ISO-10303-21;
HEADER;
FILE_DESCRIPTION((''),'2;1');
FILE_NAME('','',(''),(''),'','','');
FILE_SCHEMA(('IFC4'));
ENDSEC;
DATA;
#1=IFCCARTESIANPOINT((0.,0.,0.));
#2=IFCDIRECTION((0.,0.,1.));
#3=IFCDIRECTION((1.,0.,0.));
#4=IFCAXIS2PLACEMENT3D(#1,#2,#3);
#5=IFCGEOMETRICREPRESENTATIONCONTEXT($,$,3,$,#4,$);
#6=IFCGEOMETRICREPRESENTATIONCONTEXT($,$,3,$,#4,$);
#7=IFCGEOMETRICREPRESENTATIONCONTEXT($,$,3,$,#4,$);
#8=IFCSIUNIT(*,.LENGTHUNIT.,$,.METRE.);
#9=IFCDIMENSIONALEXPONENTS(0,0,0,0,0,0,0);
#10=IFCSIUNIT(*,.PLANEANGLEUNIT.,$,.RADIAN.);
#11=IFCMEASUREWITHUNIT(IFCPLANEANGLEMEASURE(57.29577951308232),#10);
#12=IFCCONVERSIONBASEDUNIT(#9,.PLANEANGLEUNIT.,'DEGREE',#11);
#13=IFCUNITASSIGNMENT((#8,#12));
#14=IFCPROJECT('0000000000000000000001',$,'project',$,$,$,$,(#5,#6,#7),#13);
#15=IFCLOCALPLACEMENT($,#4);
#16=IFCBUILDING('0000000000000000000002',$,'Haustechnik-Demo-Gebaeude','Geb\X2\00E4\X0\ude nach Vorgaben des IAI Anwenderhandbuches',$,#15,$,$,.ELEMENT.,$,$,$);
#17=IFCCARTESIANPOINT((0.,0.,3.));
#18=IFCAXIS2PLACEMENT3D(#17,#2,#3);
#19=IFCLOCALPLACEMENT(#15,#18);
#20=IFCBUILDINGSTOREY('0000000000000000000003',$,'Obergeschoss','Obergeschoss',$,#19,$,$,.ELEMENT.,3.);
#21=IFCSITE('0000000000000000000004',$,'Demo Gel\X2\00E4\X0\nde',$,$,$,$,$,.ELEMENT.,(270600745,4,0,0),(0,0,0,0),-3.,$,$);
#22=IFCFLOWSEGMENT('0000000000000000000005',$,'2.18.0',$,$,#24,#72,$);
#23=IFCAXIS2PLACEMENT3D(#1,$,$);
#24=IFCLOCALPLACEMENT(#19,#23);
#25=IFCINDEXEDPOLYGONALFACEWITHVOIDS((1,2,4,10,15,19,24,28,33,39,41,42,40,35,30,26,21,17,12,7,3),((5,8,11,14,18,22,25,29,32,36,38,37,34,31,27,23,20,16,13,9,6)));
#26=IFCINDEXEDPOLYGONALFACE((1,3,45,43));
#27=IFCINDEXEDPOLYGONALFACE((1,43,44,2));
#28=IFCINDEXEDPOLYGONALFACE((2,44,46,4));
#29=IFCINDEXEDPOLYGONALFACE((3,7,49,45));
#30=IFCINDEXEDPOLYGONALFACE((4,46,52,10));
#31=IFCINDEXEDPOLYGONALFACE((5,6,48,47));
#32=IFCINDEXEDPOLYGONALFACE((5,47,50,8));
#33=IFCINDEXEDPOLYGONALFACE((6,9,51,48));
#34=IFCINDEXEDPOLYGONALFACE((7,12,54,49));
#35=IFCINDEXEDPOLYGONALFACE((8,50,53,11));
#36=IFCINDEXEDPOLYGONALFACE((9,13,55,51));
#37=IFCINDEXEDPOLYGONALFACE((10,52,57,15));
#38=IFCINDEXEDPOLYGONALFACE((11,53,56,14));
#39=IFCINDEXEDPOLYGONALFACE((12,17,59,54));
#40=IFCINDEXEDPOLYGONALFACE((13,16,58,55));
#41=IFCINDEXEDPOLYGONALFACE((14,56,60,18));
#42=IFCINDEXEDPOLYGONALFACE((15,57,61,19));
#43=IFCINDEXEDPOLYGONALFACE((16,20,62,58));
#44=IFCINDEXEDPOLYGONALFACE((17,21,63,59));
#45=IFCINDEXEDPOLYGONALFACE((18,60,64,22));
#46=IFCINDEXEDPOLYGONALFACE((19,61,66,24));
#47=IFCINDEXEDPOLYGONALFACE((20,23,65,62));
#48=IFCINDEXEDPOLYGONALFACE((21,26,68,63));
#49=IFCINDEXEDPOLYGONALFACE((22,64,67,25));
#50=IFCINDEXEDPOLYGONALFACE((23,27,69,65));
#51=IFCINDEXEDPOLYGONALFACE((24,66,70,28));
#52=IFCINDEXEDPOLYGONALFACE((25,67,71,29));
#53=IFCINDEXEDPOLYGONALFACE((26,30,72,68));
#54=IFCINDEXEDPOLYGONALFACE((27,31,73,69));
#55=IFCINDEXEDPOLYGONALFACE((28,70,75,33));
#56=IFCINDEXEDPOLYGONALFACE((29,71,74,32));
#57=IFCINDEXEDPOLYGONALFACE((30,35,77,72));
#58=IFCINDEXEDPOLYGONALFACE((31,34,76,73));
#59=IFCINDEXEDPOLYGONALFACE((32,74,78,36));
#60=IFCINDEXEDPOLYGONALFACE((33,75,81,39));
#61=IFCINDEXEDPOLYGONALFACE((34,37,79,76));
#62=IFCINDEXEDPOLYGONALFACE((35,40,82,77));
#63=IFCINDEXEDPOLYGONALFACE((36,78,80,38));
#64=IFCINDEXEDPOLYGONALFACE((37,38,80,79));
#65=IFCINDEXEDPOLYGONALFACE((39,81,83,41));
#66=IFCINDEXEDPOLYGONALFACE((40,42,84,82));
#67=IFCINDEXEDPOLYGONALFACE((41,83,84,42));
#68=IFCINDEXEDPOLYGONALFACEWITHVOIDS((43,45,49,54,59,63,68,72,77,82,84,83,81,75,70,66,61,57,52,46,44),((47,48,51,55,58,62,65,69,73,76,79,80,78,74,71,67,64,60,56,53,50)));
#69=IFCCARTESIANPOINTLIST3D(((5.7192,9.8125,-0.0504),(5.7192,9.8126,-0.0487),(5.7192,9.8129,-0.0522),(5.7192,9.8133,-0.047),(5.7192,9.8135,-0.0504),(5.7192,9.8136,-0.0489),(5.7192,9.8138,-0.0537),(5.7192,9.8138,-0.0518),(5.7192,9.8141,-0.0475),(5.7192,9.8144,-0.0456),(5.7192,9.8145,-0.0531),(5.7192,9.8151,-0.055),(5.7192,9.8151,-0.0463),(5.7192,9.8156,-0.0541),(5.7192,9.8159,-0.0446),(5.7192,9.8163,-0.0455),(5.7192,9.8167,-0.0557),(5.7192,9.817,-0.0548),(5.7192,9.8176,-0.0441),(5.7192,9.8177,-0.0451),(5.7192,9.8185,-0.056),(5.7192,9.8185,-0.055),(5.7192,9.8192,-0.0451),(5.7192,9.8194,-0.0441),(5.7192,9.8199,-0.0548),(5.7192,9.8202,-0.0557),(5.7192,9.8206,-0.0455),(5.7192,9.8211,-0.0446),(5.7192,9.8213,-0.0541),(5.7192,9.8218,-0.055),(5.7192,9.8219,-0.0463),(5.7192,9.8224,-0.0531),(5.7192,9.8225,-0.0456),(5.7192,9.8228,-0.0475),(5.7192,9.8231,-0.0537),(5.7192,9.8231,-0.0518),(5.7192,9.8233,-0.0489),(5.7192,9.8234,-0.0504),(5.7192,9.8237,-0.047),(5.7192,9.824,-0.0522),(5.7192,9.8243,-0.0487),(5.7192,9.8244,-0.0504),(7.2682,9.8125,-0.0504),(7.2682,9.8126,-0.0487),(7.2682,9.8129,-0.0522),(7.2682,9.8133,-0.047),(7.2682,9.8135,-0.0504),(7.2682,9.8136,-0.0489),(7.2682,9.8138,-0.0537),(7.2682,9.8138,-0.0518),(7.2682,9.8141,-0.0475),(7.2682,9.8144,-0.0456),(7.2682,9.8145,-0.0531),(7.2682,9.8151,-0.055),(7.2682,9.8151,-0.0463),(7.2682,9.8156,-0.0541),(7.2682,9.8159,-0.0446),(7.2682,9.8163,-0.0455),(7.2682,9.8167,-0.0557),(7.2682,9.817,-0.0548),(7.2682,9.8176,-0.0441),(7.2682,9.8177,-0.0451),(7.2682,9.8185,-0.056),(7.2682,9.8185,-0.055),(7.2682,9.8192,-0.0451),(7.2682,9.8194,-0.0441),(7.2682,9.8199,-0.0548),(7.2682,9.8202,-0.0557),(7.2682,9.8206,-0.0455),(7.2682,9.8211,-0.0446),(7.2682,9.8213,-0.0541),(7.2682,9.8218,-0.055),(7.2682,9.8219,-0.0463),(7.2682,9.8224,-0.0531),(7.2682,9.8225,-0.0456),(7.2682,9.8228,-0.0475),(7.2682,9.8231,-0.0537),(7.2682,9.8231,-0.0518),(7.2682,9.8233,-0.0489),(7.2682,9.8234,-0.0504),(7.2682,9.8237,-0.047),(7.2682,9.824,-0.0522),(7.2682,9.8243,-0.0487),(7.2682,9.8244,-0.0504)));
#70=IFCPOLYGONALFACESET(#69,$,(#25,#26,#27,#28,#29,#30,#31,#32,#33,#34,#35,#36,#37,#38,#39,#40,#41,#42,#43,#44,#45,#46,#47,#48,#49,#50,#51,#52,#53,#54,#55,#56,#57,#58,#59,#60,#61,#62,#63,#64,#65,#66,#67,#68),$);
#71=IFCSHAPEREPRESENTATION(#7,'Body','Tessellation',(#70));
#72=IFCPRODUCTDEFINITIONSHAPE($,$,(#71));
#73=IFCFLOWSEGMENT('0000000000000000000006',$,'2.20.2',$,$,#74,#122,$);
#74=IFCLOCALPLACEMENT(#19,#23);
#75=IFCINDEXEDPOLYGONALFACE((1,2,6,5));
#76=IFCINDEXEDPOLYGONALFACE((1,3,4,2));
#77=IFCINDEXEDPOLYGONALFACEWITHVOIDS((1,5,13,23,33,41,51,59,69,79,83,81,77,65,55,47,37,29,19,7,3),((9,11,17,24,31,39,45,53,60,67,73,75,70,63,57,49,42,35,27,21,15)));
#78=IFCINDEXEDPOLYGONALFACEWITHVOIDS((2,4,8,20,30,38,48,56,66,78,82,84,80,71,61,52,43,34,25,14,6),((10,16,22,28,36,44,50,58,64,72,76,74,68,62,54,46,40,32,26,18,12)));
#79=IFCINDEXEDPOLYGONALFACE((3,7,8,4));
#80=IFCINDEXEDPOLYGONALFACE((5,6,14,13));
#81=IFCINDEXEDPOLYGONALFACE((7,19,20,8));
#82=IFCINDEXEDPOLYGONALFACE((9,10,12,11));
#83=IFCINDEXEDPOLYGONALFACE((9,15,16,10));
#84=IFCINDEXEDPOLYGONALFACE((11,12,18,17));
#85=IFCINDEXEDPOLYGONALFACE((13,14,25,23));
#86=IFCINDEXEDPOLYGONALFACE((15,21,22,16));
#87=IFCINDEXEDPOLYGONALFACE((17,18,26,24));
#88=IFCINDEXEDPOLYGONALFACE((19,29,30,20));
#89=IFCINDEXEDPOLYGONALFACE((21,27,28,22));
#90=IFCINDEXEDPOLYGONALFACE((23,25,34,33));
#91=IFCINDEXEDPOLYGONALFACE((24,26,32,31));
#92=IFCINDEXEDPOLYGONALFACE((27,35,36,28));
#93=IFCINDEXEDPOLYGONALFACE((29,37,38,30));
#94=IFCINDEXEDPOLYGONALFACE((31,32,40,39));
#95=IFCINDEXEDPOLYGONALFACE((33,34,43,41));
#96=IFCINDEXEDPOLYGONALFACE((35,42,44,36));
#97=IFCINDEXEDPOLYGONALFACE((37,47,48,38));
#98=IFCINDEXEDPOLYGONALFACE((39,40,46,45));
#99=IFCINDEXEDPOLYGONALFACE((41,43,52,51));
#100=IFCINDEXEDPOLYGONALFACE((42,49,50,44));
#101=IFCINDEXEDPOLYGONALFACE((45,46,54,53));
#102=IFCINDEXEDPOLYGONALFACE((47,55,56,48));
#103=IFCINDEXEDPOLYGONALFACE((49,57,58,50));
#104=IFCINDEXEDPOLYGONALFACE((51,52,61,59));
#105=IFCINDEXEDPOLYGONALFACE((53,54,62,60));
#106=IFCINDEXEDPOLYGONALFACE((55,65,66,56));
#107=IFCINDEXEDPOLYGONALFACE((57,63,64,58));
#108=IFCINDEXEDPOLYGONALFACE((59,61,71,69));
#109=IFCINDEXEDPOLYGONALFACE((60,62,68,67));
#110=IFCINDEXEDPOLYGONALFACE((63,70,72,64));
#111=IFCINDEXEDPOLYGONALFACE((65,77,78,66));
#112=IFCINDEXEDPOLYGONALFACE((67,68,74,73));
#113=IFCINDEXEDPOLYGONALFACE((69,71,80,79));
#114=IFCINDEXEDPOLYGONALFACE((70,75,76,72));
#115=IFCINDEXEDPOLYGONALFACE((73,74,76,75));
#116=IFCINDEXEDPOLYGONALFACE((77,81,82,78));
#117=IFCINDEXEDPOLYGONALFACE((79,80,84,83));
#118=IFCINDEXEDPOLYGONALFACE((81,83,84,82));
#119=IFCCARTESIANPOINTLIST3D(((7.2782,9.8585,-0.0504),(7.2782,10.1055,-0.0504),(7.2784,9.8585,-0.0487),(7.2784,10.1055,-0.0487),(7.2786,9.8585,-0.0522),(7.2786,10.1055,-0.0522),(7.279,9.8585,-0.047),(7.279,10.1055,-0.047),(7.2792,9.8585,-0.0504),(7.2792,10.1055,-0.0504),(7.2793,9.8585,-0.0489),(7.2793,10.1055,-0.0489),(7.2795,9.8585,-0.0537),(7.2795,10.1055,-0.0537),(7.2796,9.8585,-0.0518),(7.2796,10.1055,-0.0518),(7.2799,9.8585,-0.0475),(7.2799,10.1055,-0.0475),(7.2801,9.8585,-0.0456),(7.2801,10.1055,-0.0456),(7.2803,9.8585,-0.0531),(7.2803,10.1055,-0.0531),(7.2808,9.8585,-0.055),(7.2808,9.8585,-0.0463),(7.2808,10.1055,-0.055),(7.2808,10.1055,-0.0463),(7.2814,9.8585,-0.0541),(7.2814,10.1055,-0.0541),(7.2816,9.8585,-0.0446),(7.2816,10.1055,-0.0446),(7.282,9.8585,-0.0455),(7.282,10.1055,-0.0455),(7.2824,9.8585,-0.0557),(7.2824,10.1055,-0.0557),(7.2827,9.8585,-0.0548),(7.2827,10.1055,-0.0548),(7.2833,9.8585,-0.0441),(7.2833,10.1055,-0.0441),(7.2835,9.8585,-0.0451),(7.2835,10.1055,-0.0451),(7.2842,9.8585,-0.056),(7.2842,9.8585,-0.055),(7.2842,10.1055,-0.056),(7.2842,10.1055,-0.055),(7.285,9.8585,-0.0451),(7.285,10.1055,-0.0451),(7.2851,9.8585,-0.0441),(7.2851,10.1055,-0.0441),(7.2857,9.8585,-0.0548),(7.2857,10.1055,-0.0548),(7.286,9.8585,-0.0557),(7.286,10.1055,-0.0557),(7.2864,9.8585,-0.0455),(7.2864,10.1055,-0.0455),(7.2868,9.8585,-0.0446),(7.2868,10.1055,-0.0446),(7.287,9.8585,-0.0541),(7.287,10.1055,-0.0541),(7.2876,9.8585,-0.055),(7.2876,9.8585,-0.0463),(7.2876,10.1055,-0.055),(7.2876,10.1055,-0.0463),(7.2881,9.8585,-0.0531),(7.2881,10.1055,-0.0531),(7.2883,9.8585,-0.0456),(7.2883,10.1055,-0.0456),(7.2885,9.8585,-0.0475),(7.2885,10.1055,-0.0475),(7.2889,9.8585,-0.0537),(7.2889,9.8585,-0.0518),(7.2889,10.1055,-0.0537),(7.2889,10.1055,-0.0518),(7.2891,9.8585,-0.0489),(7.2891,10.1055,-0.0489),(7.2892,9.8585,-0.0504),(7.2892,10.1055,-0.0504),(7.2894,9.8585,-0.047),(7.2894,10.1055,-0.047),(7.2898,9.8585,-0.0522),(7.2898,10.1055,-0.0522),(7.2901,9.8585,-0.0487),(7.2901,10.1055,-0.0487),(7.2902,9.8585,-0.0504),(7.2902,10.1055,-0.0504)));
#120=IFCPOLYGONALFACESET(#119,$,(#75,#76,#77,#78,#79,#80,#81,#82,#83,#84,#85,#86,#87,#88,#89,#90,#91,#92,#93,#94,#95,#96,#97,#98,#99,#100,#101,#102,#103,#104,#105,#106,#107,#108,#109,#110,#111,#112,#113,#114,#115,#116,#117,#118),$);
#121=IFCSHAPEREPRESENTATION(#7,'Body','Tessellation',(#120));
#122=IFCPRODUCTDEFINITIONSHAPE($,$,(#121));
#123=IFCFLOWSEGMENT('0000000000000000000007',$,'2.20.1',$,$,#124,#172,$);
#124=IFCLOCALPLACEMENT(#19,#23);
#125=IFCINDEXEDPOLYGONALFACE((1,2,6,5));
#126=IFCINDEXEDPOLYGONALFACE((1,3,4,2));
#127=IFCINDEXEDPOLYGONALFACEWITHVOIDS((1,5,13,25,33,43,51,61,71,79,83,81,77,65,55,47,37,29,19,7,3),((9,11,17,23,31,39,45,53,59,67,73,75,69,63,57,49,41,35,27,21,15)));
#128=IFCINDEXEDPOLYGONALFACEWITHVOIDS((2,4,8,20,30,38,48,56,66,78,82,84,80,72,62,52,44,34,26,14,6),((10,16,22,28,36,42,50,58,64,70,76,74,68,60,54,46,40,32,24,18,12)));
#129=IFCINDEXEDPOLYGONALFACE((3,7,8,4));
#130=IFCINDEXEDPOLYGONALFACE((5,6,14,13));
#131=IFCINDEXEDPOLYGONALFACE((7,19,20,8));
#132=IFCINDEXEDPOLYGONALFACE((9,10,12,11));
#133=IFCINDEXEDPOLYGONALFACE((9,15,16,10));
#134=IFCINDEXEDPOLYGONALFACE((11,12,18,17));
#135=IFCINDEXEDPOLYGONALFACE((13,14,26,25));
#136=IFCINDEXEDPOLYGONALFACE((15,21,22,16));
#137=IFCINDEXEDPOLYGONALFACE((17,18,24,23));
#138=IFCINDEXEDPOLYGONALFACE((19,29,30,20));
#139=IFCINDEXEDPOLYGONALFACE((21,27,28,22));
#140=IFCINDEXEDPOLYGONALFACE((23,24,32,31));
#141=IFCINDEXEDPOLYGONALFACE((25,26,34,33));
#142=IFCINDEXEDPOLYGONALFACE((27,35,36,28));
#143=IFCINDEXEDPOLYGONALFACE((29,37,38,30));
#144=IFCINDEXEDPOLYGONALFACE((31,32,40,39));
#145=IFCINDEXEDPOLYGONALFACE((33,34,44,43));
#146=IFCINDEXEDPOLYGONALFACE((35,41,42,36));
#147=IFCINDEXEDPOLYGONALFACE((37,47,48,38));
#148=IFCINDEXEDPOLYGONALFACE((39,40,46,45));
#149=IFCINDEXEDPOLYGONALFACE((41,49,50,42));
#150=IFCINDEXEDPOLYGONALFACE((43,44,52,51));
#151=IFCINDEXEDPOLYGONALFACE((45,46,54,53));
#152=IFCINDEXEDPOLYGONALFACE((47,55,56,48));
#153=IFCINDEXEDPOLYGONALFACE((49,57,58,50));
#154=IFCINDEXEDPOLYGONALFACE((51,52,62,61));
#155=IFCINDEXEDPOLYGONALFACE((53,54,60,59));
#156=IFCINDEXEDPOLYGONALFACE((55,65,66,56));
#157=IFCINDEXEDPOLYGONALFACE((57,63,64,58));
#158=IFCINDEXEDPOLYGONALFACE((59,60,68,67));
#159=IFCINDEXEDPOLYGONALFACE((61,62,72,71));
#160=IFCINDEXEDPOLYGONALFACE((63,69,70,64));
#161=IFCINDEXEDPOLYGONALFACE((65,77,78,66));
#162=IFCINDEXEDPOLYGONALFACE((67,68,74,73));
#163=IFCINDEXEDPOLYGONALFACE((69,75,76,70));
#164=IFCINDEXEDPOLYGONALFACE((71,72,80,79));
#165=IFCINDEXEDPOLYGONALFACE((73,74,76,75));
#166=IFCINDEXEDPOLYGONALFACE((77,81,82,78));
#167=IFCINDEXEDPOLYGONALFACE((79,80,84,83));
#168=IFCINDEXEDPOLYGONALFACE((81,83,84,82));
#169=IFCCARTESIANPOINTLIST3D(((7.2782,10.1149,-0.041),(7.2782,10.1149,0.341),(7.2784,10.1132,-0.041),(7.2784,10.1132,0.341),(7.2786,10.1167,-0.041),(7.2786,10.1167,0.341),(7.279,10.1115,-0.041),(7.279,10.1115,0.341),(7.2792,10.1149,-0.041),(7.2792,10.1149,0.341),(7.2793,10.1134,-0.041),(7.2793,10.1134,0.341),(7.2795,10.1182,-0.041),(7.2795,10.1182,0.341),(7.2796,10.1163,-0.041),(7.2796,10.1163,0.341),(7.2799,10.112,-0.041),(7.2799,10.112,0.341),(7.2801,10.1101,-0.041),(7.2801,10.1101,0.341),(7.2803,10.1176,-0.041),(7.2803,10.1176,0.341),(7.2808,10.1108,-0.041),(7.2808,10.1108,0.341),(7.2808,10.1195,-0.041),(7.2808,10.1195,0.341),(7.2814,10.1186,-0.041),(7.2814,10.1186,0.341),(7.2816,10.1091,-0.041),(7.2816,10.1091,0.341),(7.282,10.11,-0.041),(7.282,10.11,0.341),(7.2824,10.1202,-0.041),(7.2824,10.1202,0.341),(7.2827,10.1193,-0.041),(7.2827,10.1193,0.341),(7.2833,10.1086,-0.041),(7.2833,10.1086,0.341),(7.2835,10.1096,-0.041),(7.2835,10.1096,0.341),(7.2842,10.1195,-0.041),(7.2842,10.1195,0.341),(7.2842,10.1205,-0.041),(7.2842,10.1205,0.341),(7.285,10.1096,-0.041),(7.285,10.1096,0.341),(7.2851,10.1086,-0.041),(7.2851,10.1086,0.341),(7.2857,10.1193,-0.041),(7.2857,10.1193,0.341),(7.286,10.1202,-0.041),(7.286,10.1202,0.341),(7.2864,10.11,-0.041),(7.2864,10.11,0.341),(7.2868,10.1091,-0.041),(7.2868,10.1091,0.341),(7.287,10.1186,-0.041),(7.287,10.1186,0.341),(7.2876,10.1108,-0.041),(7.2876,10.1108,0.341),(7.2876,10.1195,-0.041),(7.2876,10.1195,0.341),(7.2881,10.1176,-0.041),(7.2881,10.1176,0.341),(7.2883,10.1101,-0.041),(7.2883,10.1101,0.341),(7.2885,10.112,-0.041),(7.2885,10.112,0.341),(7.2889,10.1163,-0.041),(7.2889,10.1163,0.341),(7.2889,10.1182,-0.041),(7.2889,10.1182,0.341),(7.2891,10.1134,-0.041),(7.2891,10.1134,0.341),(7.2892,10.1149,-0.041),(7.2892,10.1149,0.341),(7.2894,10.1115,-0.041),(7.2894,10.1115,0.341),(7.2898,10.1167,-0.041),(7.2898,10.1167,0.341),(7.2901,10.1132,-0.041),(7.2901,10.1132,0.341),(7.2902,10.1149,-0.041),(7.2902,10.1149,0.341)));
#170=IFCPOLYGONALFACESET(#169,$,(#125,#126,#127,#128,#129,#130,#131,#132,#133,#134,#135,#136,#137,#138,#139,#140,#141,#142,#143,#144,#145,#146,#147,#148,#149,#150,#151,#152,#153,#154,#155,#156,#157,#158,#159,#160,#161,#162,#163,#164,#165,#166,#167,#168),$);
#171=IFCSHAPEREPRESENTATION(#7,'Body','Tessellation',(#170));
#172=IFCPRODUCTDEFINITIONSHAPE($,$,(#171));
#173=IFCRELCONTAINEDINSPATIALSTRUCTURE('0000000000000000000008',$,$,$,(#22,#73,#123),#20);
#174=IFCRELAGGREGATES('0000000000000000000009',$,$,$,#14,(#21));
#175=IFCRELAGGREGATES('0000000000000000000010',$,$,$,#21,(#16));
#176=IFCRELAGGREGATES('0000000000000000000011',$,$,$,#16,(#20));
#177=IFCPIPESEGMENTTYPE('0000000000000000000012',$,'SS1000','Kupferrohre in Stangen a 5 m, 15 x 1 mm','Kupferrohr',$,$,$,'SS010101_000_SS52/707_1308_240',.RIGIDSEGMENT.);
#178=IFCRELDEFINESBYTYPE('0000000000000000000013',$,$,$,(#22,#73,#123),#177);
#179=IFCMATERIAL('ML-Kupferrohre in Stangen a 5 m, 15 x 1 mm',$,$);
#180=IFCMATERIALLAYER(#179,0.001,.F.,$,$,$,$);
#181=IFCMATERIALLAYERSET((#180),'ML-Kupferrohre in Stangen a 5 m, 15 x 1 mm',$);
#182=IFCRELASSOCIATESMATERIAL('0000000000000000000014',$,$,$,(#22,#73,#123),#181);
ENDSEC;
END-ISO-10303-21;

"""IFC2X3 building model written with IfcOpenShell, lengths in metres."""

from ifc_helpers import new_model, entity, si_unit, converted_unit, frame, origin_with_axes, origin_2d_with_axis, place, context, project, spatial, hollow_circle, extrude, material, layer, layer_set, layer_usage, type_object, element, save


model = new_model("IFC2X3")

# Units and contexts
context_of_model_1 = context(None, 3, world=origin_with_axes())
context_of_model_2 = context(None, 3, world=origin_with_axes())
context_of_model_3 = context(None, 3, world=origin_with_axes())
ifc_project = project(units=[si_unit("LENGTHUNIT", "METRE"), converted_unit("PLANEANGLEUNIT", "DEGREE", entity("IfcPlaneAngleMeasure", 57.29577951308232), si_unit("PLANEANGLEUNIT", "RADIAN"), dimensions=[0, 0, 0, 0, 0, 0, 0])], contexts=[context_of_model_1, context_of_model_2, context_of_model_3])

# Site, building, storey
site = spatial("IfcSite", under=ifc_project, Name="Demo Gelände", CompositionType="ELEMENT", RefLatitude=(270600745, 4, 0, 0), RefLongitude=(0, 0, 0, 0), RefElevation=-3.0)
building_placement = place(None, origin_with_axes())
building = spatial("IfcBuilding", under=site, at=building_placement, Name="Haustechnik-Demo-Gebaeude", Description="Gebäude nach Vorgaben des IAI Anwenderhandbuches", CompositionType="ELEMENT")
storey_placement = place(building_placement, frame((0.0, 0.0, 3.0), z_axis=(0.0, 0.0, 1.0), x_axis=(1.0, 0.0, 0.0)))
storey = spatial("IfcBuildingStorey", under=building, at=storey_placement, Name="Obergeschoss", Description="Obergeschoss", CompositionType="ELEMENT", Elevation=3.0)

# Flow segments
ifc_material_1 = material(Name="ML-Kupferrohre in Stangen a 5 m, 15 x 1 mm")
ifc_layer_1 = layer(ifc_material_1, 0.001, ventilated=False)
ifc_layer_set_1 = layer_set([ifc_layer_1], Name="ML-Kupferrohre in Stangen a 5 m, 15 x 1 mm")
ifc_layer_usage_1 = layer_usage(ifc_layer_set_1, "AXIS2", "POSITIVE", 0.0)
pipe_segment_type_1 = type_object("IfcPipeSegmentType", Name="SS1000", Description="Kupferrohre in Stangen a 5 m, 15 x 1 mm", ApplicableOccurrence="Kupferrohr", ElementType="SS010101_000_SS52/707_1308_240", PredefinedType="RIGIDSEGMENT")
flow_segment_1_placement = place(storey_placement, frame((5.7192, 9.8185, -0.05), z_axis=(1.0, 0.0, 0.0), x_axis=(0.0, 0.0, -1.0)))
element("IfcFlowSegment", 1, at=flow_segment_1_placement, inside=storey, type_object=pipe_segment_type_1, material=ifc_layer_usage_1, Name="2.18.0", context=context_of_model_3, shape_type="SweptSolid", body=[
    extrude(hollow_circle(Radius=0.006, WallThickness=0.001, at=origin_2d_with_axis()), origin_with_axes(), (0.0, 0.0, 1.0), 1.549),
])
flow_segment_2_placement = place(storey_placement, frame((7.2842, 9.8585, -0.05), z_axis=(0.0, 1.0, 0.0), x_axis=(0.0, 0.0, -1.0)))
element("IfcFlowSegment", 2, at=flow_segment_2_placement, inside=storey, type_object=pipe_segment_type_1, material=ifc_layer_usage_1, Name="2.20.2", context=context_of_model_3, shape_type="SweptSolid", body=[
    extrude(hollow_circle(Radius=0.006, WallThickness=0.001, at=origin_2d_with_axis()), origin_with_axes(), (0.0, 0.0, 1.0), 0.247),
])
flow_segment_3_placement = place(storey_placement, frame((7.2842, 10.1145, -0.041), z_axis=(0.0, 0.0, 1.0), x_axis=(0.0, 1.0, 0.0)))
element("IfcFlowSegment", 3, at=flow_segment_3_placement, inside=storey, type_object=pipe_segment_type_1, material=ifc_layer_usage_1, Name="2.20.1", context=context_of_model_3, shape_type="SweptSolid", body=[
    extrude(hollow_circle(Radius=0.006, WallThickness=0.001, at=origin_2d_with_axis()), origin_with_axes(), (0.0, 0.0, 1.0), 0.382),
])

save(model, "model.ifc")
